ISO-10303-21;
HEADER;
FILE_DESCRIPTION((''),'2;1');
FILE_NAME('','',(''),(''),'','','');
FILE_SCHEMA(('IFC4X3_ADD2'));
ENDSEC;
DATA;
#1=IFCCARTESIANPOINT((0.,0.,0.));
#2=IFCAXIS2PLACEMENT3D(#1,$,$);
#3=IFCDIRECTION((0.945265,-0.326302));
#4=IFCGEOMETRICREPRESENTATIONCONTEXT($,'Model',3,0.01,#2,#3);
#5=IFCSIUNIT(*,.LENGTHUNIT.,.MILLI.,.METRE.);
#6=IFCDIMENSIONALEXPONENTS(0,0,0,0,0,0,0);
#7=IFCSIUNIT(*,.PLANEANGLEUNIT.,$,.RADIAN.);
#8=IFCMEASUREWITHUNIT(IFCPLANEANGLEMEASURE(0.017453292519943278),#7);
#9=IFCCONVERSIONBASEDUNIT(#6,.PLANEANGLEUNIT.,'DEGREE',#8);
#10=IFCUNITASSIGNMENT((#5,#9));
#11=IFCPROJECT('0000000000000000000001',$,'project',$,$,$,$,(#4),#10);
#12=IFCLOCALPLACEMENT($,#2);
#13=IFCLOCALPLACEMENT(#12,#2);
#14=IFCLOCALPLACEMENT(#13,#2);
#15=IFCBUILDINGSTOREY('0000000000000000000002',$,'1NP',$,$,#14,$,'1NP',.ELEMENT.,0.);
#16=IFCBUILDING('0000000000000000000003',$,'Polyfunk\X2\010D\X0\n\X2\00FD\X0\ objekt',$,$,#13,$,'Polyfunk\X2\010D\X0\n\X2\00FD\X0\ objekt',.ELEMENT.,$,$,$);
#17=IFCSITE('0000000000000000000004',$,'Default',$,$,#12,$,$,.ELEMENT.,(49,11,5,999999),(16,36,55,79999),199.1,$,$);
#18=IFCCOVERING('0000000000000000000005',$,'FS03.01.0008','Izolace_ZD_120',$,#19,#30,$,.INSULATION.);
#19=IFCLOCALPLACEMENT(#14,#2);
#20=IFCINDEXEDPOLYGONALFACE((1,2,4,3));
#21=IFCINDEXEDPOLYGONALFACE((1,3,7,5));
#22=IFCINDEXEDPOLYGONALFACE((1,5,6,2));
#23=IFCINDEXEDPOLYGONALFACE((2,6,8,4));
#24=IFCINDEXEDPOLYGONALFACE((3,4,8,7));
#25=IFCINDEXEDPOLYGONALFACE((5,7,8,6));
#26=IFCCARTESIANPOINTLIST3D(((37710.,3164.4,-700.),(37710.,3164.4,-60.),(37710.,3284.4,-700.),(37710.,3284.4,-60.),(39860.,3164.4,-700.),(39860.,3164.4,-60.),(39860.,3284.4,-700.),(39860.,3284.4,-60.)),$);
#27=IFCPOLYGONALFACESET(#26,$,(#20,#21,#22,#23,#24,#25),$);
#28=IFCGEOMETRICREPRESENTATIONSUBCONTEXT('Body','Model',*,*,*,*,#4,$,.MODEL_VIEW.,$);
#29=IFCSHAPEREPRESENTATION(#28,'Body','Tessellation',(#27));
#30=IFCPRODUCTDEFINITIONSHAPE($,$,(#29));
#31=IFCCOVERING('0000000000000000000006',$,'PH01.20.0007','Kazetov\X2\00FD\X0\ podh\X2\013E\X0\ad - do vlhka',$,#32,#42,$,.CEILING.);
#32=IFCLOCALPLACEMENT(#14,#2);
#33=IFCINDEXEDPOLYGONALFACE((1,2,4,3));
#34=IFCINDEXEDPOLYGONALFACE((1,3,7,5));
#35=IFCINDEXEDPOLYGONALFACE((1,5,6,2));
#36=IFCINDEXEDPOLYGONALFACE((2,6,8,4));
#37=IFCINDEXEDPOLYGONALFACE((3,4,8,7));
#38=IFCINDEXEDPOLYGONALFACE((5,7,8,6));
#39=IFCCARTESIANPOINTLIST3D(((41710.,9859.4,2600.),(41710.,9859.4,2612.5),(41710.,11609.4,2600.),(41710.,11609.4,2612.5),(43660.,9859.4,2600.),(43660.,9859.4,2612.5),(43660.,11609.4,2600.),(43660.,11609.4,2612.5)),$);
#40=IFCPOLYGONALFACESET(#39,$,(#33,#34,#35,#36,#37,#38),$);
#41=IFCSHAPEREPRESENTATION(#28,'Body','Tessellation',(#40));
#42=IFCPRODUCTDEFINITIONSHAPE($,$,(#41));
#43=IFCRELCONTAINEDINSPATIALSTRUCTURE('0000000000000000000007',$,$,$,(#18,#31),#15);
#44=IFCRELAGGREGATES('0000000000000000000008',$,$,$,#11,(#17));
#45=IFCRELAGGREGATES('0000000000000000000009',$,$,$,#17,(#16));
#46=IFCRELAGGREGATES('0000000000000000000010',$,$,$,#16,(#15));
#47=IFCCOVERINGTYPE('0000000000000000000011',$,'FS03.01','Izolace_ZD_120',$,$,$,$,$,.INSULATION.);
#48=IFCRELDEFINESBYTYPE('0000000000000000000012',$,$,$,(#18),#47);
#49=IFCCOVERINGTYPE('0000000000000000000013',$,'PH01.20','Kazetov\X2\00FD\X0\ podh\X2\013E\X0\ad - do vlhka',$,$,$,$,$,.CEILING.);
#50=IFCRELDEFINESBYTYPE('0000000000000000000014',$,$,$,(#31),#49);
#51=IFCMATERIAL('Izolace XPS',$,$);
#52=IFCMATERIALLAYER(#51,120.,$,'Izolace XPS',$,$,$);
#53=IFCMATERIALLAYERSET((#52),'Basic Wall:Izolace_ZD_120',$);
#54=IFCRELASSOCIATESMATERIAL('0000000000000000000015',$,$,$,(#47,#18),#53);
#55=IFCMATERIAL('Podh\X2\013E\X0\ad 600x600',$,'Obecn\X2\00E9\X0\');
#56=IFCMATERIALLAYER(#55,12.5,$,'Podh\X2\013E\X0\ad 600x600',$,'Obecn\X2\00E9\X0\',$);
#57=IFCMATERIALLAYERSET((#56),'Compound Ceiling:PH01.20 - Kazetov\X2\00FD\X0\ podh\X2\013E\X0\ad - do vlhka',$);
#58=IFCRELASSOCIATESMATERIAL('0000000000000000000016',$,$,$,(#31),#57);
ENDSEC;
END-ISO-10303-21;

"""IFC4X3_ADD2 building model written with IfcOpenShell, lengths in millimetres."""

from ifc_helpers import new_model, entity, si_unit, converted_unit, direction, frame, frame_2d, origin, place, context, subcontext, project, spatial, rectangle, extrude, material, layer, layer_set, layer_usage, type_object, element, save


model = new_model("IFC4X3_ADD2")

# Units and contexts
model_context = context("Model", 3, precision=0.01, world=origin(), true_north=direction((0.945265, -0.326302)))
body_context = subcontext(model_context, "Body", "Model", "MODEL_VIEW")
ifc_project = project(units=[si_unit("LENGTHUNIT", "METRE", prefix="MILLI"), converted_unit("PLANEANGLEUNIT", "DEGREE", entity("IfcPlaneAngleMeasure", 0.017453292519943278), si_unit("PLANEANGLEUNIT", "RADIAN"), dimensions=[0, 0, 0, 0, 0, 0, 0])], contexts=[model_context])

# Site, building, storey
site_placement = place(None, origin())
site = spatial("IfcSite", under=ifc_project, at=site_placement, Name="Default", CompositionType="ELEMENT", RefLatitude=(49, 11, 5, 999999), RefLongitude=(16, 36, 55, 79999), RefElevation=199.1)
building_placement = place(site_placement, origin())
building = spatial("IfcBuilding", under=site, at=building_placement, Name="Polyfunkčný objekt", LongName="Polyfunkčný objekt", CompositionType="ELEMENT")
storey_placement = place(building_placement, origin())
storey = spatial("IfcBuildingStorey", under=building, at=storey_placement, Name="1NP", LongName="1NP", CompositionType="ELEMENT", Elevation=0.0)

# Coverings
ifc_material_1 = material(Name="Podhľad 600x600", Category="Obecné")
ifc_material_2 = material(Name="Izolace XPS")
ifc_layer_1 = layer(ifc_material_2, 120.0, Name="Izolace XPS")
ifc_layer_set_1 = layer_set([ifc_layer_1], Name="Basic Wall:Izolace_ZD_120")
covering_type_1 = type_object("IfcCoveringType", Name="FS03.01", Description="Izolace_ZD_120", PredefinedType="INSULATION", material=ifc_layer_set_1)
covering_1_placement = place(storey_placement, frame((37710.0, 3224.4, -700.0)))
element("IfcCovering", 1, at=covering_1_placement, inside=storey, type_object=covering_type_1, material=ifc_layer_set_1, Name="FS03.01.0008", Description="Izolace_ZD_120", PredefinedType="INSULATION", context=body_context, shape_type="SweptSolid", body=[
    extrude(rectangle(XDim=2150.0, YDim=120.0, at=frame_2d((1075.0, 0.0), x_axis=(-1.0, 0.0))), origin(), (0.0, 0.0, 1.0), 640.0),
])
ifc_layer_2 = layer(ifc_material_1, 12.5, Name="Podhľad 600x600", Category="Obecné")
ifc_layer_set_2 = layer_set([ifc_layer_2], Name="Compound Ceiling:PH01.20 - Kazetový podhľad - do vlhka")
ifc_layer_usage_1 = layer_usage(ifc_layer_set_2, "AXIS3", "NEGATIVE", 0.0)
covering_type_2 = type_object("IfcCoveringType", Name="PH01.20", Description="Kazetový podhľad - do vlhka", PredefinedType="CEILING")
covering_2_placement = place(storey_placement, frame((41710.0, 9859.4, 2600.0)))
element("IfcCovering", 2, at=covering_2_placement, inside=storey, type_object=covering_type_2, material=ifc_layer_usage_1, Name="PH01.20.0007", Description="Kazetový podhľad - do vlhka", PredefinedType="CEILING", context=body_context, shape_type="SweptSolid", body=[
    extrude(rectangle(XDim=1950.0, YDim=1750.0, at=frame_2d((0.0, 0.0), x_axis=(1.0, 0.0))), frame((975.0, 875.0, 0.0), z_axis=(0.0, 0.0, 1.0), x_axis=(-1.0, 0.0, 0.0)), (0.0, 0.0, 1.0), 12.5),
])

save(model, "model.ifc")
